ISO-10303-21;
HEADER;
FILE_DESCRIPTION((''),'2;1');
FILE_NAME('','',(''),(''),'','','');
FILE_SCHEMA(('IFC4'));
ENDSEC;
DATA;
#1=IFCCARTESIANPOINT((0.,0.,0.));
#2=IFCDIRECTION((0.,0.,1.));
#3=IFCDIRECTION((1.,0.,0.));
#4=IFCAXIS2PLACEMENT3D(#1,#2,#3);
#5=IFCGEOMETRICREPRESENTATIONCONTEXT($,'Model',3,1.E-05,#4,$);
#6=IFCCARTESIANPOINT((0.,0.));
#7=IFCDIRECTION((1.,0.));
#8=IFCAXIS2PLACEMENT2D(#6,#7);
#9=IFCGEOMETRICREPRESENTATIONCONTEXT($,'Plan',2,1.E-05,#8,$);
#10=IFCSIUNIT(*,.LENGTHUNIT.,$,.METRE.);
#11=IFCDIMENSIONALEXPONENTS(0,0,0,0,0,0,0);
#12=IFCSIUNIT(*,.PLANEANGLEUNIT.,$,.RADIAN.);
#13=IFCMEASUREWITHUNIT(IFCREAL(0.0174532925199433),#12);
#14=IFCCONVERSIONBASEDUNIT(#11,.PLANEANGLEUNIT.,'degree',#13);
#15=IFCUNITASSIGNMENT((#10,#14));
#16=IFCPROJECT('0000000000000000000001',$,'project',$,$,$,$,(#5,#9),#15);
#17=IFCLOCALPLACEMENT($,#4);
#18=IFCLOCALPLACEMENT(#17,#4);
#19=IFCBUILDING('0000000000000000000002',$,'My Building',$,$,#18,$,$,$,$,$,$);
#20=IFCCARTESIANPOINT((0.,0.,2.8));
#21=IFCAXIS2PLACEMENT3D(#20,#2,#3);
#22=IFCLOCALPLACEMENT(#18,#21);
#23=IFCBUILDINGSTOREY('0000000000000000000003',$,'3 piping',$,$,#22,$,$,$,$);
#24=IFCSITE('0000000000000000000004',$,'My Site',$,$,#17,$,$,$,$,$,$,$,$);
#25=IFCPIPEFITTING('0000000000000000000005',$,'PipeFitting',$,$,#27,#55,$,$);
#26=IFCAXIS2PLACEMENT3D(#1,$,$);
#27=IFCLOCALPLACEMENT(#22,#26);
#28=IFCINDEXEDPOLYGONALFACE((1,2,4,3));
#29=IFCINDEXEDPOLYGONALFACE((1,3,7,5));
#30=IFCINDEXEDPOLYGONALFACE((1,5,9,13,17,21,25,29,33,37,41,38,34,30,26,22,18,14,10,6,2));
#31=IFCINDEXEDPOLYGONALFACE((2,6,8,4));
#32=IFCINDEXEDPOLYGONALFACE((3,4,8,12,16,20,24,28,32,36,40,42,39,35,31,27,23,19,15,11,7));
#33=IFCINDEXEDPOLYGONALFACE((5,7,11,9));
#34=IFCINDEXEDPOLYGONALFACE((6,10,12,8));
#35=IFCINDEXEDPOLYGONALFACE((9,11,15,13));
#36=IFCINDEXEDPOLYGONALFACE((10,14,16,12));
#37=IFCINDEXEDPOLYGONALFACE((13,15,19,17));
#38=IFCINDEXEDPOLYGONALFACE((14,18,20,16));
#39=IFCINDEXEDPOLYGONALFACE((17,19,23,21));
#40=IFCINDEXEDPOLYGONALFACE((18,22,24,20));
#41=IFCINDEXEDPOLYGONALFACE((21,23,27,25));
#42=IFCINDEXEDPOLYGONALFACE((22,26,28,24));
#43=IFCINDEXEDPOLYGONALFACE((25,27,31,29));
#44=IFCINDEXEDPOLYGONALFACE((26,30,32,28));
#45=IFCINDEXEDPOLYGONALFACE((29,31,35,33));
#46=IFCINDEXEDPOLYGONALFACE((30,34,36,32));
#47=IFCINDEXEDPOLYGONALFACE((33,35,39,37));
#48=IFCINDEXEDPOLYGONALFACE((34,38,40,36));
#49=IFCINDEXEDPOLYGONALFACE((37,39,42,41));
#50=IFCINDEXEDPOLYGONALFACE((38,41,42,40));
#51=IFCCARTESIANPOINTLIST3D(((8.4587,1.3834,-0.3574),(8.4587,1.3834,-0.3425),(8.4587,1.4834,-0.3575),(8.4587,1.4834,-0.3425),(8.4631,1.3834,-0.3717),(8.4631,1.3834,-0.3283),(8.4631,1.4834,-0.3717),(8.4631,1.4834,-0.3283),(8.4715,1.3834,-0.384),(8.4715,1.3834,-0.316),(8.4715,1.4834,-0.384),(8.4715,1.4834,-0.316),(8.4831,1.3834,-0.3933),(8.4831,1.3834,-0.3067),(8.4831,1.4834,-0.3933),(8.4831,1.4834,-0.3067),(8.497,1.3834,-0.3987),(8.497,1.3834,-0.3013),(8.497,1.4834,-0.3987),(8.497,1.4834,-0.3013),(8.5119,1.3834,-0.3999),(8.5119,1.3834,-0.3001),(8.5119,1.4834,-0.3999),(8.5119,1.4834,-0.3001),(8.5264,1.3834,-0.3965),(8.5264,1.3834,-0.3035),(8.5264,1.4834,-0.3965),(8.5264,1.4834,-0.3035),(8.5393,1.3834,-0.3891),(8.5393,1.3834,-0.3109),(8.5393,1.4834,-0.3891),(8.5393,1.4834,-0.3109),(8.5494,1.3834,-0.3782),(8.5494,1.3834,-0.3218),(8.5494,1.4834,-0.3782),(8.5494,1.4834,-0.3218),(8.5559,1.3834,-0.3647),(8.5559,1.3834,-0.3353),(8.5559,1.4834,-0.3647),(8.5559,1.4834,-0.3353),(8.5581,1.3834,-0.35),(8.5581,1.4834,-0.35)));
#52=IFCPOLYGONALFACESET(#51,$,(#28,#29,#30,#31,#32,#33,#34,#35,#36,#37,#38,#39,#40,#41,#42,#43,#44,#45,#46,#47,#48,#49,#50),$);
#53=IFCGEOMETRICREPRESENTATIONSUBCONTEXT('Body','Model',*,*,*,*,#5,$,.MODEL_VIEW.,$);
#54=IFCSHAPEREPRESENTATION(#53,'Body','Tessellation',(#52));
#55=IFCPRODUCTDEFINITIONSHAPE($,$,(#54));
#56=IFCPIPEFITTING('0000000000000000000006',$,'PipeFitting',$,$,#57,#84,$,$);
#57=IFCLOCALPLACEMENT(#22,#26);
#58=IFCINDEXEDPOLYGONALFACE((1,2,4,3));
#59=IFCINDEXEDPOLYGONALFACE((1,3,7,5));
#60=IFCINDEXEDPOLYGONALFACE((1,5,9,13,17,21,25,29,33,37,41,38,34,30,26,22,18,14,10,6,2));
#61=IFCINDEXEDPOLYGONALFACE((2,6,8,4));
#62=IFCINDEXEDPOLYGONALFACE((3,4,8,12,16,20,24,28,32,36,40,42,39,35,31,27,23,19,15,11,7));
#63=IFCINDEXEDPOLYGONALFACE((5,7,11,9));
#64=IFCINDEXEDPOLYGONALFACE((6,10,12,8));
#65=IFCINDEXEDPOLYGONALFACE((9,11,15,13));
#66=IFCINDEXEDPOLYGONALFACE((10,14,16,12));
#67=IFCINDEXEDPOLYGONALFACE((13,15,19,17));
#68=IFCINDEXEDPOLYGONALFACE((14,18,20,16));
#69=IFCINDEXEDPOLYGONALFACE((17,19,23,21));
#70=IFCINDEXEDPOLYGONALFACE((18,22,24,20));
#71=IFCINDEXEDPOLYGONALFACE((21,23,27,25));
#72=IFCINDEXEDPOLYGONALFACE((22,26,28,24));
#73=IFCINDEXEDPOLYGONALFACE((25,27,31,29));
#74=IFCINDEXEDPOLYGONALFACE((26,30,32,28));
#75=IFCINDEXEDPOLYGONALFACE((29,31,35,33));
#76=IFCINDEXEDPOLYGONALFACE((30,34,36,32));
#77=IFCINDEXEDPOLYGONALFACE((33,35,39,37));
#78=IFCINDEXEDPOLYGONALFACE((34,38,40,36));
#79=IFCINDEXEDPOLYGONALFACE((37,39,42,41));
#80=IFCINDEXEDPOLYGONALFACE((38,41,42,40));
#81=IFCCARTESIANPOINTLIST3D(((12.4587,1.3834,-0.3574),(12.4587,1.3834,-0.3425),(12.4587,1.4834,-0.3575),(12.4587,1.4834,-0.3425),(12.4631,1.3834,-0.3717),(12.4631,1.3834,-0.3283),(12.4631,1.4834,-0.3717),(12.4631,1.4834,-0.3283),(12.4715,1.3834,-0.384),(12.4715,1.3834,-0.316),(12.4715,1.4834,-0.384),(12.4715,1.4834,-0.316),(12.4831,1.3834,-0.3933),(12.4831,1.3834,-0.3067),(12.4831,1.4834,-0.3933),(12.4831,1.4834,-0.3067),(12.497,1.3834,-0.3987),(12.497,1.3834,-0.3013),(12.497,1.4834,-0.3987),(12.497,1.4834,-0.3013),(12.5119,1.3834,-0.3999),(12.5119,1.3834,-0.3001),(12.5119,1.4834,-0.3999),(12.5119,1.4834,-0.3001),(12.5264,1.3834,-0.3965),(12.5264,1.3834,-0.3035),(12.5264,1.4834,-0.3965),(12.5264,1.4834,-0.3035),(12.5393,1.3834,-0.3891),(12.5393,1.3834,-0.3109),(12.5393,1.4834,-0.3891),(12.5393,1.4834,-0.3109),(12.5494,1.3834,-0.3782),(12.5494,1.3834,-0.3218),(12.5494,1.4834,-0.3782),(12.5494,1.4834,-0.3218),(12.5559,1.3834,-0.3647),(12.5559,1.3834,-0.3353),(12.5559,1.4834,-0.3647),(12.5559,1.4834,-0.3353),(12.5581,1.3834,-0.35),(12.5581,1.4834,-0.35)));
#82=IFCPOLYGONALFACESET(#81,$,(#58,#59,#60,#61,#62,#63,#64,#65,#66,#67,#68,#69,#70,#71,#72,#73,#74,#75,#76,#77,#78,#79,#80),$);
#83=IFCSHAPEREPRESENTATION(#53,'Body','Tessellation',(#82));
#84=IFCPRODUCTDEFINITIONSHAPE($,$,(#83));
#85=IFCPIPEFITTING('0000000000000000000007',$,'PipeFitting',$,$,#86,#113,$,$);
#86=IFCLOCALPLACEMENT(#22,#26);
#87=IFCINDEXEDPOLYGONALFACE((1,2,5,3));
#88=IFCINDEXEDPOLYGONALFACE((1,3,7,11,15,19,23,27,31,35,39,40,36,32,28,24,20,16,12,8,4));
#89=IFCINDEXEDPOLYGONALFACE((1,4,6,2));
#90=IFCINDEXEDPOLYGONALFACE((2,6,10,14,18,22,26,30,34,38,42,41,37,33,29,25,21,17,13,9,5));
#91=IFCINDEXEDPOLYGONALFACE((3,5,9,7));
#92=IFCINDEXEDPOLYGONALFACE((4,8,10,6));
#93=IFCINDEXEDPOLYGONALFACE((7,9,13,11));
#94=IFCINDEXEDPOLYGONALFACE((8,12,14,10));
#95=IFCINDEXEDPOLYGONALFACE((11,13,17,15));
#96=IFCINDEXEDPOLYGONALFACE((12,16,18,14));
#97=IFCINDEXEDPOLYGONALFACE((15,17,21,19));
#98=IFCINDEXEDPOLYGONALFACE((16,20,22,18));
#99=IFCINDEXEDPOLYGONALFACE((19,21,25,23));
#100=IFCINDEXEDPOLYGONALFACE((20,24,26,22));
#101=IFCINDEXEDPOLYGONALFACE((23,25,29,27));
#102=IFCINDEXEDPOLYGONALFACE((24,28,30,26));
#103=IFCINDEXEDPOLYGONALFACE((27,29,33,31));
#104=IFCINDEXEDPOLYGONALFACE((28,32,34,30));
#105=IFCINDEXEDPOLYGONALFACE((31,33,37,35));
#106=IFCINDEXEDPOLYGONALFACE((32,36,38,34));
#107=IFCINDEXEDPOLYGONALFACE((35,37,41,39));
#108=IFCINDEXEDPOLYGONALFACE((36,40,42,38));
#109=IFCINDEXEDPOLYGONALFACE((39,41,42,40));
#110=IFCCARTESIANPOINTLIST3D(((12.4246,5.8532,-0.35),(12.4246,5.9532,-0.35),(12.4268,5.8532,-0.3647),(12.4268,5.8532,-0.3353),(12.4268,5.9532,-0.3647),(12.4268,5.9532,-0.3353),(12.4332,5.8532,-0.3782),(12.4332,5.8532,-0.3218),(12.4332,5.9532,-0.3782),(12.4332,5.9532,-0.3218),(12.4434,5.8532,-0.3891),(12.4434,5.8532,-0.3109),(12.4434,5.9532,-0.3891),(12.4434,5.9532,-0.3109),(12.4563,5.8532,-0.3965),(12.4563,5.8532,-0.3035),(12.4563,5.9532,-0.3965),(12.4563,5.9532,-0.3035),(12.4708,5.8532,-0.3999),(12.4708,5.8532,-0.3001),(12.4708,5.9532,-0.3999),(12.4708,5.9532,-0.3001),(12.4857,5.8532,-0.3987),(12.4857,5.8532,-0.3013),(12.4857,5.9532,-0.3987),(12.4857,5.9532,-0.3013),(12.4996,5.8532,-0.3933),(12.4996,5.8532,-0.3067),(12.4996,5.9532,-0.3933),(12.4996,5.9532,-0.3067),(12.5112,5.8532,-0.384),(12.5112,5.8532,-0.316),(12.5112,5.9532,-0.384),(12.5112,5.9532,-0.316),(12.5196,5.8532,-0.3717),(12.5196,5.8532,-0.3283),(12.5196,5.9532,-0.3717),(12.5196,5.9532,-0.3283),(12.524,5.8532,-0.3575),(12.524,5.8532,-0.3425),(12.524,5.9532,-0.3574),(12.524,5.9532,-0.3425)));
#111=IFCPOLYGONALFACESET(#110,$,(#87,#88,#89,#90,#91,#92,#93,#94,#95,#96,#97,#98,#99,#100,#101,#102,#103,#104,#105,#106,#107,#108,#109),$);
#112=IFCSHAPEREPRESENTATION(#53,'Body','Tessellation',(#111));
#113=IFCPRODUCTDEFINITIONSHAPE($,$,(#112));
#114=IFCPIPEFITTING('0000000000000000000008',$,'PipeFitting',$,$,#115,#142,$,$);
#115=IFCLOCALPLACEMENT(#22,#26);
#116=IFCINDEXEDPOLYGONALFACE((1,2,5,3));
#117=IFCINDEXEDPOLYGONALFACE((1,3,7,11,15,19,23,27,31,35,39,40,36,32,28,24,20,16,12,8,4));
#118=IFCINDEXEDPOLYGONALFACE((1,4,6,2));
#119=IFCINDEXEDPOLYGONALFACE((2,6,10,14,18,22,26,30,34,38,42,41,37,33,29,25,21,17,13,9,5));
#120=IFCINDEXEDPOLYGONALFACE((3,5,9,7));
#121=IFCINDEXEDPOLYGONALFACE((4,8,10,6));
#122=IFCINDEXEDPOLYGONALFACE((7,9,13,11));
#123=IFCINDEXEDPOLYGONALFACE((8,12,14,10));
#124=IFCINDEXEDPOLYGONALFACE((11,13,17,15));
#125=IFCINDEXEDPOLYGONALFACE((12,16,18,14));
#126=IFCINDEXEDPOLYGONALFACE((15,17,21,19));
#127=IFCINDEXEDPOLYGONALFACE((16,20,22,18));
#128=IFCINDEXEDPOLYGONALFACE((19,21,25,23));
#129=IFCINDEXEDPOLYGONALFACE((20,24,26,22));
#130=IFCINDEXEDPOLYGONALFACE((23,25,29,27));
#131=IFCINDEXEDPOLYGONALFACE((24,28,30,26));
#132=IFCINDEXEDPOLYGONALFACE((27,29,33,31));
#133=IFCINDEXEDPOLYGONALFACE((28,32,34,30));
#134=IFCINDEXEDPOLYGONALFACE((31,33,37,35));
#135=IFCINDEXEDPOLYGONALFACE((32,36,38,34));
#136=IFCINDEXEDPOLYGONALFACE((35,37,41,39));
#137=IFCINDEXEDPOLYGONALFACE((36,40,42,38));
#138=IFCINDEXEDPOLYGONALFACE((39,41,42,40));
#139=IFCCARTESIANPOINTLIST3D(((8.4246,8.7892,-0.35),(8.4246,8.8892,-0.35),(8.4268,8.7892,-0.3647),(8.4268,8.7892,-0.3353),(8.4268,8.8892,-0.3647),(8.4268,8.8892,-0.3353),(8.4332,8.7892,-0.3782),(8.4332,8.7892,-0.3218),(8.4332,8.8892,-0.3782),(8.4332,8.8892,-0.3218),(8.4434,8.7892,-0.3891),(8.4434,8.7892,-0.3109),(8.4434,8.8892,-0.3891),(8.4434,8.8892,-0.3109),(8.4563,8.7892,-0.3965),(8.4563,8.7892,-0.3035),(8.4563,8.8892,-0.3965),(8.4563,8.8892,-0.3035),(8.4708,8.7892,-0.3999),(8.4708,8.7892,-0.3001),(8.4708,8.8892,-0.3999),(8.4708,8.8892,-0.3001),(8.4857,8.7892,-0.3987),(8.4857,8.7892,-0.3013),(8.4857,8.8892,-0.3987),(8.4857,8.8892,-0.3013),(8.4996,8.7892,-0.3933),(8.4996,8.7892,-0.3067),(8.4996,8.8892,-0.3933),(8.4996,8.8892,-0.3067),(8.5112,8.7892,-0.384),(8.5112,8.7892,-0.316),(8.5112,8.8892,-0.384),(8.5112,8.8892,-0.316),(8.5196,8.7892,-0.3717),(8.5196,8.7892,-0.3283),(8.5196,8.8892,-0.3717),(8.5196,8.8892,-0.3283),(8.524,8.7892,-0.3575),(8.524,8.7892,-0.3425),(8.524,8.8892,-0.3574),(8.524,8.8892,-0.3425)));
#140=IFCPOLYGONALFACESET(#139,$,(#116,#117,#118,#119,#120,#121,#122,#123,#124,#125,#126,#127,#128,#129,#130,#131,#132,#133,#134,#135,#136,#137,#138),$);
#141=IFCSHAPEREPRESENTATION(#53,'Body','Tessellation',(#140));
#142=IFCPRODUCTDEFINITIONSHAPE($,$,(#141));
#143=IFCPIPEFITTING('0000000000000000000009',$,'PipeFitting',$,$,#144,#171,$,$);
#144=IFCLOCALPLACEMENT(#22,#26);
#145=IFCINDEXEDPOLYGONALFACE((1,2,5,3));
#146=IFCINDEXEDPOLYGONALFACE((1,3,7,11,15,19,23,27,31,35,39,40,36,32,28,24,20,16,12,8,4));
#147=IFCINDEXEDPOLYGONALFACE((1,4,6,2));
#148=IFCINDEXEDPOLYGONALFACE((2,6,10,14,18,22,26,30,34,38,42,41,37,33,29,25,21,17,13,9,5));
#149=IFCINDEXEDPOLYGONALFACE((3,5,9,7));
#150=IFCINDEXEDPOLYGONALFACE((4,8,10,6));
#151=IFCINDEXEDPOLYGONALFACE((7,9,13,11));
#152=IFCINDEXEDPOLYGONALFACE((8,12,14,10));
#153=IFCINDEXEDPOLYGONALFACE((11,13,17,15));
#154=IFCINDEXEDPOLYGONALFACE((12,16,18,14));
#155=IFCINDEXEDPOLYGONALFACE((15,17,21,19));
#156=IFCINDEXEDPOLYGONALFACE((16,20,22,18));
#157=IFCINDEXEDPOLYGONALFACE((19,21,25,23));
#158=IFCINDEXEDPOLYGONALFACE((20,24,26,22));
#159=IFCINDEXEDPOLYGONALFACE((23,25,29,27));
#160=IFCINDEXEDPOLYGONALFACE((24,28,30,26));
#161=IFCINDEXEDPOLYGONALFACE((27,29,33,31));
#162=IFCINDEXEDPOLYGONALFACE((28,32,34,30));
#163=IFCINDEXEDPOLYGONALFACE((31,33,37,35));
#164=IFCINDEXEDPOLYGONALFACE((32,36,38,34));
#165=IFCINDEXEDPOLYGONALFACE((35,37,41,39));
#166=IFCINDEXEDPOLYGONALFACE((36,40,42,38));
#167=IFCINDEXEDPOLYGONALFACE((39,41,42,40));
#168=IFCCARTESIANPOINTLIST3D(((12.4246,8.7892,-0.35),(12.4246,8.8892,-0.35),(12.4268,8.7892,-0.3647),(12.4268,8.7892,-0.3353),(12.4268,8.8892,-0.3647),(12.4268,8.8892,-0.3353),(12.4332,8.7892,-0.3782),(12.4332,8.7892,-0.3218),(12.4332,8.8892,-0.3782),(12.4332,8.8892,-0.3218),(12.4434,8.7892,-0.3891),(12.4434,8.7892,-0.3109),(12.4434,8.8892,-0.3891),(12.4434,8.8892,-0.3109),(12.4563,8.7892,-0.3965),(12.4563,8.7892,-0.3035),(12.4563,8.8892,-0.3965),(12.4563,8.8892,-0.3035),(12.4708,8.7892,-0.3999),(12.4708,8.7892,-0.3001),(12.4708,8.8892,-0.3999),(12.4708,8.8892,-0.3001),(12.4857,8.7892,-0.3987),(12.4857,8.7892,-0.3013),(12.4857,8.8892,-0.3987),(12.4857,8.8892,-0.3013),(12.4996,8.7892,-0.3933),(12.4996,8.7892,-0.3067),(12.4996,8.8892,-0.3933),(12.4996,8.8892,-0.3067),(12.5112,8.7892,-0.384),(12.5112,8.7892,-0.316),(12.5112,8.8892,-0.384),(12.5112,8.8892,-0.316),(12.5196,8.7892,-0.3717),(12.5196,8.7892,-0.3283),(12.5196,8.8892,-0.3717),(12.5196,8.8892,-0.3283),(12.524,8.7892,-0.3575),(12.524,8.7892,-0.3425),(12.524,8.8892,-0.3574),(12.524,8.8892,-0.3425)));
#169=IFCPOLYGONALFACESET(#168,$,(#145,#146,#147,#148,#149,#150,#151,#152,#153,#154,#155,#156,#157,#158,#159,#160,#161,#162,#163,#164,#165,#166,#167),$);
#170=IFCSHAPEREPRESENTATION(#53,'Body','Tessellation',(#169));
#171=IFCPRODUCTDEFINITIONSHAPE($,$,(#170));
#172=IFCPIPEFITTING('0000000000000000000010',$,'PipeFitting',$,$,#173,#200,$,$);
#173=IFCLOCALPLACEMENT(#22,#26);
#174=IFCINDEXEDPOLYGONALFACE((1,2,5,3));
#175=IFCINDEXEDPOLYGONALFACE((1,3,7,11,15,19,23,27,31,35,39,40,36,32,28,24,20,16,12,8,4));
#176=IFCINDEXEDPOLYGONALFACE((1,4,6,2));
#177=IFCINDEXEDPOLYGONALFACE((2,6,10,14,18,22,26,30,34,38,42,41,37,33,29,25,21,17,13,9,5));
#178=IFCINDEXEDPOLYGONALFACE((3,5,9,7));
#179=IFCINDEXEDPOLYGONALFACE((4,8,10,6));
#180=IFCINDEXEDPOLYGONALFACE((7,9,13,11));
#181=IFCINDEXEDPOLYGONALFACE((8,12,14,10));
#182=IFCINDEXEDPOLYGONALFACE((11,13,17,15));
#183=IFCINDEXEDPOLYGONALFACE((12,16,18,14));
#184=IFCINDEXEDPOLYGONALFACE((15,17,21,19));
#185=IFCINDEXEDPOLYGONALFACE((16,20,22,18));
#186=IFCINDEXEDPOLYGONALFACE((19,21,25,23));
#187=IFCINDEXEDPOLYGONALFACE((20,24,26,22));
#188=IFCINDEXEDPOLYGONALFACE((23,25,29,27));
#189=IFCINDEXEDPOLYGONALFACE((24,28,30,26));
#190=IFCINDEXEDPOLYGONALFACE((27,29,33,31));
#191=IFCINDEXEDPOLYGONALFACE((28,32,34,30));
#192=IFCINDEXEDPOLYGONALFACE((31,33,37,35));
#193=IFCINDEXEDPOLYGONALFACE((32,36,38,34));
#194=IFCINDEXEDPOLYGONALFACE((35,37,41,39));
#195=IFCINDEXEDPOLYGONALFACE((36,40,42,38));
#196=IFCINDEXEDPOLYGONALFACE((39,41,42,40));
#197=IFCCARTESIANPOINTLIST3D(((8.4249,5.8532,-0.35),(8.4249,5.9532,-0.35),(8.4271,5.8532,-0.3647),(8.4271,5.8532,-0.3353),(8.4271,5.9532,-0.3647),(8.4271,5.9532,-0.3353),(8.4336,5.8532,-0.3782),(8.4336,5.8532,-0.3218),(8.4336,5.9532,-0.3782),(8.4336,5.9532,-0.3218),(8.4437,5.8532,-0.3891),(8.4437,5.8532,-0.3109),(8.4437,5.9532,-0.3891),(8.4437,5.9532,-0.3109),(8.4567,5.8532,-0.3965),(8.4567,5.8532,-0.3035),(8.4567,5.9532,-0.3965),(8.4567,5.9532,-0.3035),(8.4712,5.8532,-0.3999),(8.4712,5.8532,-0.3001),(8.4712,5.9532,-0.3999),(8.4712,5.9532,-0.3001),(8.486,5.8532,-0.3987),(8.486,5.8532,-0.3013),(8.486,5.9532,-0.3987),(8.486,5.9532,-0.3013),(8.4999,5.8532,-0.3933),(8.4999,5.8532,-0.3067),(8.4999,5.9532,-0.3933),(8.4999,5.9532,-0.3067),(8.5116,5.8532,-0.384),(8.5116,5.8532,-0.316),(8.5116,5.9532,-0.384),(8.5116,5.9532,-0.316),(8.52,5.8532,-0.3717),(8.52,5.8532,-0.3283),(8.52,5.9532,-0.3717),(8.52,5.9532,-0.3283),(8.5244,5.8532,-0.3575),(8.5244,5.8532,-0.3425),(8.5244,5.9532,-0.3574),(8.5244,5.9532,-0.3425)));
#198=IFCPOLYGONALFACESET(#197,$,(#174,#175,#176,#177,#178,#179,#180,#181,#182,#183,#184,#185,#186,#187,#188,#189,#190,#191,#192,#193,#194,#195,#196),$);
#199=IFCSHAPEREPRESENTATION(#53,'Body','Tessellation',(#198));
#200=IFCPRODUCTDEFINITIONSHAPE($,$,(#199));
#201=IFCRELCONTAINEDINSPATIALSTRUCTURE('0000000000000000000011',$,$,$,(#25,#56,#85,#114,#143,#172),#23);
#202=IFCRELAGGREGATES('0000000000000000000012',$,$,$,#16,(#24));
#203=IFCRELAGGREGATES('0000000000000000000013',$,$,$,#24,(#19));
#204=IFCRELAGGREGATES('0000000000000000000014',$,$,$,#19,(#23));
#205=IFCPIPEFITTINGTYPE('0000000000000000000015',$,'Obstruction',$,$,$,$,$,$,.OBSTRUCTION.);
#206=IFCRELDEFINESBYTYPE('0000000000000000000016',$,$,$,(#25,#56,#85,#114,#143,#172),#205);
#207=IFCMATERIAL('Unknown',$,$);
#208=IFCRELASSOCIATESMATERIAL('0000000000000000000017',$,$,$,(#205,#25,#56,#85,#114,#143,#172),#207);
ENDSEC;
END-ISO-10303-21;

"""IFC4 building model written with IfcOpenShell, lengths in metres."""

from ifc_helpers import new_model, entity, si_unit, converted_unit, frame, origin_with_axes, origin_2d_with_axis, place, context, subcontext, project, spatial, circle, extrude, material, material_profile, profile_set, profile_usage, type_object, element, save


model = new_model("IFC4")

# Units and contexts
model_context = context("Model", 3, precision=1e-05, world=origin_with_axes())
plan_context = context("Plan", 2, precision=1e-05, world=origin_2d_with_axis())
body_context = subcontext(model_context, "Body", "Model", "MODEL_VIEW")
ifc_project = project(units=[si_unit("LENGTHUNIT", "METRE"), converted_unit("PLANEANGLEUNIT", "degree", entity("IfcReal", 0.0174532925199433), si_unit("PLANEANGLEUNIT", "RADIAN"), dimensions=[0, 0, 0, 0, 0, 0, 0])], contexts=[model_context, plan_context])

# Site, building, storey
site_placement = place(None, origin_with_axes())
site = spatial("IfcSite", under=ifc_project, at=site_placement, Name="My Site")
building_placement = place(site_placement, origin_with_axes())
building = spatial("IfcBuilding", under=site, at=building_placement, Name="My Building")
storey_placement = place(building_placement, frame((0.0, 0.0, 2.8), z_axis=(0.0, 0.0, 1.0), x_axis=(1.0, 0.0, 0.0)))
storey = spatial("IfcBuildingStorey", under=building, at=storey_placement, Name="3 piping")

# Shared definitions
ifc_material = material(Name="Unknown")

# Pipe fittings
ifc_material_profile_1 = material_profile(ifc_material, circle(Radius=0.05))
ifc_profile_set_1 = profile_set([ifc_material_profile_1])
ifc_profile_usage_1 = profile_usage(ifc_profile_set_1, cardinal=5)
pipe_fitting_type_1 = type_object("IfcPipeFittingType", Name="Obstruction", PredefinedType="OBSTRUCTION", material=ifc_profile_set_1)
pipe_fitting_1_placement = place(storey_placement, frame((8.5081, 1.4834, -0.35), z_axis=(0.0, -1.0, 0.000025), x_axis=(1.0, 0.0, 0.0)))
element("IfcPipeFitting", 1, at=pipe_fitting_1_placement, inside=storey, type_object=pipe_fitting_type_1, material=ifc_profile_usage_1, Name="PipeFitting", context=body_context, shape_type="SweptSolid", body=[
    extrude(circle(Radius=0.05), origin_with_axes(), (0.0, 0.0, 1.0), 0.1),
])
ifc_profile_usage_2 = profile_usage(ifc_profile_set_1, cardinal=5)
pipe_fitting_2_placement = place(storey_placement, frame((12.5081, 1.4834, -0.35), z_axis=(0.0, -1.0, 0.000025), x_axis=(1.0, 0.0, 0.0)))
element("IfcPipeFitting", 2, at=pipe_fitting_2_placement, inside=storey, type_object=pipe_fitting_type_1, material=ifc_profile_usage_2, Name="PipeFitting", context=body_context, shape_type="SweptSolid", body=[
    extrude(circle(Radius=0.05), origin_with_axes(), (0.0, 0.0, 1.0), 0.1),
])
ifc_profile_usage_3 = profile_usage(ifc_profile_set_1, cardinal=5)
pipe_fitting_3_placement = place(storey_placement, frame((12.4746, 5.8532, -0.35), z_axis=(0.0, 1.0, 0.000025), x_axis=(-1.0, 0.0, 0.0)))
element("IfcPipeFitting", 3, at=pipe_fitting_3_placement, inside=storey, type_object=pipe_fitting_type_1, material=ifc_profile_usage_3, Name="PipeFitting", context=body_context, shape_type="SweptSolid", body=[
    extrude(circle(Radius=0.05), origin_with_axes(), (0.0, 0.0, 1.0), 0.1),
])
ifc_profile_usage_4 = profile_usage(ifc_profile_set_1, cardinal=5)
pipe_fitting_4_placement = place(storey_placement, frame((8.4746, 8.7892, -0.35), z_axis=(0.0, 1.0, 0.000025), x_axis=(-1.0, 0.0, 0.0)))
element("IfcPipeFitting", 4, at=pipe_fitting_4_placement, inside=storey, type_object=pipe_fitting_type_1, material=ifc_profile_usage_4, Name="PipeFitting", context=body_context, shape_type="SweptSolid", body=[
    extrude(circle(Radius=0.05), origin_with_axes(), (0.0, 0.0, 1.0), 0.1),
])
ifc_profile_usage_5 = profile_usage(ifc_profile_set_1, cardinal=5)
pipe_fitting_5_placement = place(storey_placement, frame((12.4746, 8.7892, -0.35), z_axis=(0.0, 1.0, 0.000025), x_axis=(-1.0, 0.0, 0.0)))
element("IfcPipeFitting", 5, at=pipe_fitting_5_placement, inside=storey, type_object=pipe_fitting_type_1, material=ifc_profile_usage_5, Name="PipeFitting", context=body_context, shape_type="SweptSolid", body=[
    extrude(circle(Radius=0.05), origin_with_axes(), (0.0, 0.0, 1.0), 0.1),
])
ifc_profile_usage_6 = profile_usage(ifc_profile_set_1, cardinal=5)
pipe_fitting_6_placement = place(storey_placement, frame((8.4749, 5.8532, -0.35), z_axis=(0.0, 1.0, 0.000025), x_axis=(-1.0, 0.0, 0.0)))
element("IfcPipeFitting", 6, at=pipe_fitting_6_placement, inside=storey, type_object=pipe_fitting_type_1, material=ifc_profile_usage_6, Name="PipeFitting", context=body_context, shape_type="SweptSolid", body=[
    extrude(circle(Radius=0.05), origin_with_axes(), (0.0, 0.0, 1.0), 0.1),
])

save(model, "model.ifc")
